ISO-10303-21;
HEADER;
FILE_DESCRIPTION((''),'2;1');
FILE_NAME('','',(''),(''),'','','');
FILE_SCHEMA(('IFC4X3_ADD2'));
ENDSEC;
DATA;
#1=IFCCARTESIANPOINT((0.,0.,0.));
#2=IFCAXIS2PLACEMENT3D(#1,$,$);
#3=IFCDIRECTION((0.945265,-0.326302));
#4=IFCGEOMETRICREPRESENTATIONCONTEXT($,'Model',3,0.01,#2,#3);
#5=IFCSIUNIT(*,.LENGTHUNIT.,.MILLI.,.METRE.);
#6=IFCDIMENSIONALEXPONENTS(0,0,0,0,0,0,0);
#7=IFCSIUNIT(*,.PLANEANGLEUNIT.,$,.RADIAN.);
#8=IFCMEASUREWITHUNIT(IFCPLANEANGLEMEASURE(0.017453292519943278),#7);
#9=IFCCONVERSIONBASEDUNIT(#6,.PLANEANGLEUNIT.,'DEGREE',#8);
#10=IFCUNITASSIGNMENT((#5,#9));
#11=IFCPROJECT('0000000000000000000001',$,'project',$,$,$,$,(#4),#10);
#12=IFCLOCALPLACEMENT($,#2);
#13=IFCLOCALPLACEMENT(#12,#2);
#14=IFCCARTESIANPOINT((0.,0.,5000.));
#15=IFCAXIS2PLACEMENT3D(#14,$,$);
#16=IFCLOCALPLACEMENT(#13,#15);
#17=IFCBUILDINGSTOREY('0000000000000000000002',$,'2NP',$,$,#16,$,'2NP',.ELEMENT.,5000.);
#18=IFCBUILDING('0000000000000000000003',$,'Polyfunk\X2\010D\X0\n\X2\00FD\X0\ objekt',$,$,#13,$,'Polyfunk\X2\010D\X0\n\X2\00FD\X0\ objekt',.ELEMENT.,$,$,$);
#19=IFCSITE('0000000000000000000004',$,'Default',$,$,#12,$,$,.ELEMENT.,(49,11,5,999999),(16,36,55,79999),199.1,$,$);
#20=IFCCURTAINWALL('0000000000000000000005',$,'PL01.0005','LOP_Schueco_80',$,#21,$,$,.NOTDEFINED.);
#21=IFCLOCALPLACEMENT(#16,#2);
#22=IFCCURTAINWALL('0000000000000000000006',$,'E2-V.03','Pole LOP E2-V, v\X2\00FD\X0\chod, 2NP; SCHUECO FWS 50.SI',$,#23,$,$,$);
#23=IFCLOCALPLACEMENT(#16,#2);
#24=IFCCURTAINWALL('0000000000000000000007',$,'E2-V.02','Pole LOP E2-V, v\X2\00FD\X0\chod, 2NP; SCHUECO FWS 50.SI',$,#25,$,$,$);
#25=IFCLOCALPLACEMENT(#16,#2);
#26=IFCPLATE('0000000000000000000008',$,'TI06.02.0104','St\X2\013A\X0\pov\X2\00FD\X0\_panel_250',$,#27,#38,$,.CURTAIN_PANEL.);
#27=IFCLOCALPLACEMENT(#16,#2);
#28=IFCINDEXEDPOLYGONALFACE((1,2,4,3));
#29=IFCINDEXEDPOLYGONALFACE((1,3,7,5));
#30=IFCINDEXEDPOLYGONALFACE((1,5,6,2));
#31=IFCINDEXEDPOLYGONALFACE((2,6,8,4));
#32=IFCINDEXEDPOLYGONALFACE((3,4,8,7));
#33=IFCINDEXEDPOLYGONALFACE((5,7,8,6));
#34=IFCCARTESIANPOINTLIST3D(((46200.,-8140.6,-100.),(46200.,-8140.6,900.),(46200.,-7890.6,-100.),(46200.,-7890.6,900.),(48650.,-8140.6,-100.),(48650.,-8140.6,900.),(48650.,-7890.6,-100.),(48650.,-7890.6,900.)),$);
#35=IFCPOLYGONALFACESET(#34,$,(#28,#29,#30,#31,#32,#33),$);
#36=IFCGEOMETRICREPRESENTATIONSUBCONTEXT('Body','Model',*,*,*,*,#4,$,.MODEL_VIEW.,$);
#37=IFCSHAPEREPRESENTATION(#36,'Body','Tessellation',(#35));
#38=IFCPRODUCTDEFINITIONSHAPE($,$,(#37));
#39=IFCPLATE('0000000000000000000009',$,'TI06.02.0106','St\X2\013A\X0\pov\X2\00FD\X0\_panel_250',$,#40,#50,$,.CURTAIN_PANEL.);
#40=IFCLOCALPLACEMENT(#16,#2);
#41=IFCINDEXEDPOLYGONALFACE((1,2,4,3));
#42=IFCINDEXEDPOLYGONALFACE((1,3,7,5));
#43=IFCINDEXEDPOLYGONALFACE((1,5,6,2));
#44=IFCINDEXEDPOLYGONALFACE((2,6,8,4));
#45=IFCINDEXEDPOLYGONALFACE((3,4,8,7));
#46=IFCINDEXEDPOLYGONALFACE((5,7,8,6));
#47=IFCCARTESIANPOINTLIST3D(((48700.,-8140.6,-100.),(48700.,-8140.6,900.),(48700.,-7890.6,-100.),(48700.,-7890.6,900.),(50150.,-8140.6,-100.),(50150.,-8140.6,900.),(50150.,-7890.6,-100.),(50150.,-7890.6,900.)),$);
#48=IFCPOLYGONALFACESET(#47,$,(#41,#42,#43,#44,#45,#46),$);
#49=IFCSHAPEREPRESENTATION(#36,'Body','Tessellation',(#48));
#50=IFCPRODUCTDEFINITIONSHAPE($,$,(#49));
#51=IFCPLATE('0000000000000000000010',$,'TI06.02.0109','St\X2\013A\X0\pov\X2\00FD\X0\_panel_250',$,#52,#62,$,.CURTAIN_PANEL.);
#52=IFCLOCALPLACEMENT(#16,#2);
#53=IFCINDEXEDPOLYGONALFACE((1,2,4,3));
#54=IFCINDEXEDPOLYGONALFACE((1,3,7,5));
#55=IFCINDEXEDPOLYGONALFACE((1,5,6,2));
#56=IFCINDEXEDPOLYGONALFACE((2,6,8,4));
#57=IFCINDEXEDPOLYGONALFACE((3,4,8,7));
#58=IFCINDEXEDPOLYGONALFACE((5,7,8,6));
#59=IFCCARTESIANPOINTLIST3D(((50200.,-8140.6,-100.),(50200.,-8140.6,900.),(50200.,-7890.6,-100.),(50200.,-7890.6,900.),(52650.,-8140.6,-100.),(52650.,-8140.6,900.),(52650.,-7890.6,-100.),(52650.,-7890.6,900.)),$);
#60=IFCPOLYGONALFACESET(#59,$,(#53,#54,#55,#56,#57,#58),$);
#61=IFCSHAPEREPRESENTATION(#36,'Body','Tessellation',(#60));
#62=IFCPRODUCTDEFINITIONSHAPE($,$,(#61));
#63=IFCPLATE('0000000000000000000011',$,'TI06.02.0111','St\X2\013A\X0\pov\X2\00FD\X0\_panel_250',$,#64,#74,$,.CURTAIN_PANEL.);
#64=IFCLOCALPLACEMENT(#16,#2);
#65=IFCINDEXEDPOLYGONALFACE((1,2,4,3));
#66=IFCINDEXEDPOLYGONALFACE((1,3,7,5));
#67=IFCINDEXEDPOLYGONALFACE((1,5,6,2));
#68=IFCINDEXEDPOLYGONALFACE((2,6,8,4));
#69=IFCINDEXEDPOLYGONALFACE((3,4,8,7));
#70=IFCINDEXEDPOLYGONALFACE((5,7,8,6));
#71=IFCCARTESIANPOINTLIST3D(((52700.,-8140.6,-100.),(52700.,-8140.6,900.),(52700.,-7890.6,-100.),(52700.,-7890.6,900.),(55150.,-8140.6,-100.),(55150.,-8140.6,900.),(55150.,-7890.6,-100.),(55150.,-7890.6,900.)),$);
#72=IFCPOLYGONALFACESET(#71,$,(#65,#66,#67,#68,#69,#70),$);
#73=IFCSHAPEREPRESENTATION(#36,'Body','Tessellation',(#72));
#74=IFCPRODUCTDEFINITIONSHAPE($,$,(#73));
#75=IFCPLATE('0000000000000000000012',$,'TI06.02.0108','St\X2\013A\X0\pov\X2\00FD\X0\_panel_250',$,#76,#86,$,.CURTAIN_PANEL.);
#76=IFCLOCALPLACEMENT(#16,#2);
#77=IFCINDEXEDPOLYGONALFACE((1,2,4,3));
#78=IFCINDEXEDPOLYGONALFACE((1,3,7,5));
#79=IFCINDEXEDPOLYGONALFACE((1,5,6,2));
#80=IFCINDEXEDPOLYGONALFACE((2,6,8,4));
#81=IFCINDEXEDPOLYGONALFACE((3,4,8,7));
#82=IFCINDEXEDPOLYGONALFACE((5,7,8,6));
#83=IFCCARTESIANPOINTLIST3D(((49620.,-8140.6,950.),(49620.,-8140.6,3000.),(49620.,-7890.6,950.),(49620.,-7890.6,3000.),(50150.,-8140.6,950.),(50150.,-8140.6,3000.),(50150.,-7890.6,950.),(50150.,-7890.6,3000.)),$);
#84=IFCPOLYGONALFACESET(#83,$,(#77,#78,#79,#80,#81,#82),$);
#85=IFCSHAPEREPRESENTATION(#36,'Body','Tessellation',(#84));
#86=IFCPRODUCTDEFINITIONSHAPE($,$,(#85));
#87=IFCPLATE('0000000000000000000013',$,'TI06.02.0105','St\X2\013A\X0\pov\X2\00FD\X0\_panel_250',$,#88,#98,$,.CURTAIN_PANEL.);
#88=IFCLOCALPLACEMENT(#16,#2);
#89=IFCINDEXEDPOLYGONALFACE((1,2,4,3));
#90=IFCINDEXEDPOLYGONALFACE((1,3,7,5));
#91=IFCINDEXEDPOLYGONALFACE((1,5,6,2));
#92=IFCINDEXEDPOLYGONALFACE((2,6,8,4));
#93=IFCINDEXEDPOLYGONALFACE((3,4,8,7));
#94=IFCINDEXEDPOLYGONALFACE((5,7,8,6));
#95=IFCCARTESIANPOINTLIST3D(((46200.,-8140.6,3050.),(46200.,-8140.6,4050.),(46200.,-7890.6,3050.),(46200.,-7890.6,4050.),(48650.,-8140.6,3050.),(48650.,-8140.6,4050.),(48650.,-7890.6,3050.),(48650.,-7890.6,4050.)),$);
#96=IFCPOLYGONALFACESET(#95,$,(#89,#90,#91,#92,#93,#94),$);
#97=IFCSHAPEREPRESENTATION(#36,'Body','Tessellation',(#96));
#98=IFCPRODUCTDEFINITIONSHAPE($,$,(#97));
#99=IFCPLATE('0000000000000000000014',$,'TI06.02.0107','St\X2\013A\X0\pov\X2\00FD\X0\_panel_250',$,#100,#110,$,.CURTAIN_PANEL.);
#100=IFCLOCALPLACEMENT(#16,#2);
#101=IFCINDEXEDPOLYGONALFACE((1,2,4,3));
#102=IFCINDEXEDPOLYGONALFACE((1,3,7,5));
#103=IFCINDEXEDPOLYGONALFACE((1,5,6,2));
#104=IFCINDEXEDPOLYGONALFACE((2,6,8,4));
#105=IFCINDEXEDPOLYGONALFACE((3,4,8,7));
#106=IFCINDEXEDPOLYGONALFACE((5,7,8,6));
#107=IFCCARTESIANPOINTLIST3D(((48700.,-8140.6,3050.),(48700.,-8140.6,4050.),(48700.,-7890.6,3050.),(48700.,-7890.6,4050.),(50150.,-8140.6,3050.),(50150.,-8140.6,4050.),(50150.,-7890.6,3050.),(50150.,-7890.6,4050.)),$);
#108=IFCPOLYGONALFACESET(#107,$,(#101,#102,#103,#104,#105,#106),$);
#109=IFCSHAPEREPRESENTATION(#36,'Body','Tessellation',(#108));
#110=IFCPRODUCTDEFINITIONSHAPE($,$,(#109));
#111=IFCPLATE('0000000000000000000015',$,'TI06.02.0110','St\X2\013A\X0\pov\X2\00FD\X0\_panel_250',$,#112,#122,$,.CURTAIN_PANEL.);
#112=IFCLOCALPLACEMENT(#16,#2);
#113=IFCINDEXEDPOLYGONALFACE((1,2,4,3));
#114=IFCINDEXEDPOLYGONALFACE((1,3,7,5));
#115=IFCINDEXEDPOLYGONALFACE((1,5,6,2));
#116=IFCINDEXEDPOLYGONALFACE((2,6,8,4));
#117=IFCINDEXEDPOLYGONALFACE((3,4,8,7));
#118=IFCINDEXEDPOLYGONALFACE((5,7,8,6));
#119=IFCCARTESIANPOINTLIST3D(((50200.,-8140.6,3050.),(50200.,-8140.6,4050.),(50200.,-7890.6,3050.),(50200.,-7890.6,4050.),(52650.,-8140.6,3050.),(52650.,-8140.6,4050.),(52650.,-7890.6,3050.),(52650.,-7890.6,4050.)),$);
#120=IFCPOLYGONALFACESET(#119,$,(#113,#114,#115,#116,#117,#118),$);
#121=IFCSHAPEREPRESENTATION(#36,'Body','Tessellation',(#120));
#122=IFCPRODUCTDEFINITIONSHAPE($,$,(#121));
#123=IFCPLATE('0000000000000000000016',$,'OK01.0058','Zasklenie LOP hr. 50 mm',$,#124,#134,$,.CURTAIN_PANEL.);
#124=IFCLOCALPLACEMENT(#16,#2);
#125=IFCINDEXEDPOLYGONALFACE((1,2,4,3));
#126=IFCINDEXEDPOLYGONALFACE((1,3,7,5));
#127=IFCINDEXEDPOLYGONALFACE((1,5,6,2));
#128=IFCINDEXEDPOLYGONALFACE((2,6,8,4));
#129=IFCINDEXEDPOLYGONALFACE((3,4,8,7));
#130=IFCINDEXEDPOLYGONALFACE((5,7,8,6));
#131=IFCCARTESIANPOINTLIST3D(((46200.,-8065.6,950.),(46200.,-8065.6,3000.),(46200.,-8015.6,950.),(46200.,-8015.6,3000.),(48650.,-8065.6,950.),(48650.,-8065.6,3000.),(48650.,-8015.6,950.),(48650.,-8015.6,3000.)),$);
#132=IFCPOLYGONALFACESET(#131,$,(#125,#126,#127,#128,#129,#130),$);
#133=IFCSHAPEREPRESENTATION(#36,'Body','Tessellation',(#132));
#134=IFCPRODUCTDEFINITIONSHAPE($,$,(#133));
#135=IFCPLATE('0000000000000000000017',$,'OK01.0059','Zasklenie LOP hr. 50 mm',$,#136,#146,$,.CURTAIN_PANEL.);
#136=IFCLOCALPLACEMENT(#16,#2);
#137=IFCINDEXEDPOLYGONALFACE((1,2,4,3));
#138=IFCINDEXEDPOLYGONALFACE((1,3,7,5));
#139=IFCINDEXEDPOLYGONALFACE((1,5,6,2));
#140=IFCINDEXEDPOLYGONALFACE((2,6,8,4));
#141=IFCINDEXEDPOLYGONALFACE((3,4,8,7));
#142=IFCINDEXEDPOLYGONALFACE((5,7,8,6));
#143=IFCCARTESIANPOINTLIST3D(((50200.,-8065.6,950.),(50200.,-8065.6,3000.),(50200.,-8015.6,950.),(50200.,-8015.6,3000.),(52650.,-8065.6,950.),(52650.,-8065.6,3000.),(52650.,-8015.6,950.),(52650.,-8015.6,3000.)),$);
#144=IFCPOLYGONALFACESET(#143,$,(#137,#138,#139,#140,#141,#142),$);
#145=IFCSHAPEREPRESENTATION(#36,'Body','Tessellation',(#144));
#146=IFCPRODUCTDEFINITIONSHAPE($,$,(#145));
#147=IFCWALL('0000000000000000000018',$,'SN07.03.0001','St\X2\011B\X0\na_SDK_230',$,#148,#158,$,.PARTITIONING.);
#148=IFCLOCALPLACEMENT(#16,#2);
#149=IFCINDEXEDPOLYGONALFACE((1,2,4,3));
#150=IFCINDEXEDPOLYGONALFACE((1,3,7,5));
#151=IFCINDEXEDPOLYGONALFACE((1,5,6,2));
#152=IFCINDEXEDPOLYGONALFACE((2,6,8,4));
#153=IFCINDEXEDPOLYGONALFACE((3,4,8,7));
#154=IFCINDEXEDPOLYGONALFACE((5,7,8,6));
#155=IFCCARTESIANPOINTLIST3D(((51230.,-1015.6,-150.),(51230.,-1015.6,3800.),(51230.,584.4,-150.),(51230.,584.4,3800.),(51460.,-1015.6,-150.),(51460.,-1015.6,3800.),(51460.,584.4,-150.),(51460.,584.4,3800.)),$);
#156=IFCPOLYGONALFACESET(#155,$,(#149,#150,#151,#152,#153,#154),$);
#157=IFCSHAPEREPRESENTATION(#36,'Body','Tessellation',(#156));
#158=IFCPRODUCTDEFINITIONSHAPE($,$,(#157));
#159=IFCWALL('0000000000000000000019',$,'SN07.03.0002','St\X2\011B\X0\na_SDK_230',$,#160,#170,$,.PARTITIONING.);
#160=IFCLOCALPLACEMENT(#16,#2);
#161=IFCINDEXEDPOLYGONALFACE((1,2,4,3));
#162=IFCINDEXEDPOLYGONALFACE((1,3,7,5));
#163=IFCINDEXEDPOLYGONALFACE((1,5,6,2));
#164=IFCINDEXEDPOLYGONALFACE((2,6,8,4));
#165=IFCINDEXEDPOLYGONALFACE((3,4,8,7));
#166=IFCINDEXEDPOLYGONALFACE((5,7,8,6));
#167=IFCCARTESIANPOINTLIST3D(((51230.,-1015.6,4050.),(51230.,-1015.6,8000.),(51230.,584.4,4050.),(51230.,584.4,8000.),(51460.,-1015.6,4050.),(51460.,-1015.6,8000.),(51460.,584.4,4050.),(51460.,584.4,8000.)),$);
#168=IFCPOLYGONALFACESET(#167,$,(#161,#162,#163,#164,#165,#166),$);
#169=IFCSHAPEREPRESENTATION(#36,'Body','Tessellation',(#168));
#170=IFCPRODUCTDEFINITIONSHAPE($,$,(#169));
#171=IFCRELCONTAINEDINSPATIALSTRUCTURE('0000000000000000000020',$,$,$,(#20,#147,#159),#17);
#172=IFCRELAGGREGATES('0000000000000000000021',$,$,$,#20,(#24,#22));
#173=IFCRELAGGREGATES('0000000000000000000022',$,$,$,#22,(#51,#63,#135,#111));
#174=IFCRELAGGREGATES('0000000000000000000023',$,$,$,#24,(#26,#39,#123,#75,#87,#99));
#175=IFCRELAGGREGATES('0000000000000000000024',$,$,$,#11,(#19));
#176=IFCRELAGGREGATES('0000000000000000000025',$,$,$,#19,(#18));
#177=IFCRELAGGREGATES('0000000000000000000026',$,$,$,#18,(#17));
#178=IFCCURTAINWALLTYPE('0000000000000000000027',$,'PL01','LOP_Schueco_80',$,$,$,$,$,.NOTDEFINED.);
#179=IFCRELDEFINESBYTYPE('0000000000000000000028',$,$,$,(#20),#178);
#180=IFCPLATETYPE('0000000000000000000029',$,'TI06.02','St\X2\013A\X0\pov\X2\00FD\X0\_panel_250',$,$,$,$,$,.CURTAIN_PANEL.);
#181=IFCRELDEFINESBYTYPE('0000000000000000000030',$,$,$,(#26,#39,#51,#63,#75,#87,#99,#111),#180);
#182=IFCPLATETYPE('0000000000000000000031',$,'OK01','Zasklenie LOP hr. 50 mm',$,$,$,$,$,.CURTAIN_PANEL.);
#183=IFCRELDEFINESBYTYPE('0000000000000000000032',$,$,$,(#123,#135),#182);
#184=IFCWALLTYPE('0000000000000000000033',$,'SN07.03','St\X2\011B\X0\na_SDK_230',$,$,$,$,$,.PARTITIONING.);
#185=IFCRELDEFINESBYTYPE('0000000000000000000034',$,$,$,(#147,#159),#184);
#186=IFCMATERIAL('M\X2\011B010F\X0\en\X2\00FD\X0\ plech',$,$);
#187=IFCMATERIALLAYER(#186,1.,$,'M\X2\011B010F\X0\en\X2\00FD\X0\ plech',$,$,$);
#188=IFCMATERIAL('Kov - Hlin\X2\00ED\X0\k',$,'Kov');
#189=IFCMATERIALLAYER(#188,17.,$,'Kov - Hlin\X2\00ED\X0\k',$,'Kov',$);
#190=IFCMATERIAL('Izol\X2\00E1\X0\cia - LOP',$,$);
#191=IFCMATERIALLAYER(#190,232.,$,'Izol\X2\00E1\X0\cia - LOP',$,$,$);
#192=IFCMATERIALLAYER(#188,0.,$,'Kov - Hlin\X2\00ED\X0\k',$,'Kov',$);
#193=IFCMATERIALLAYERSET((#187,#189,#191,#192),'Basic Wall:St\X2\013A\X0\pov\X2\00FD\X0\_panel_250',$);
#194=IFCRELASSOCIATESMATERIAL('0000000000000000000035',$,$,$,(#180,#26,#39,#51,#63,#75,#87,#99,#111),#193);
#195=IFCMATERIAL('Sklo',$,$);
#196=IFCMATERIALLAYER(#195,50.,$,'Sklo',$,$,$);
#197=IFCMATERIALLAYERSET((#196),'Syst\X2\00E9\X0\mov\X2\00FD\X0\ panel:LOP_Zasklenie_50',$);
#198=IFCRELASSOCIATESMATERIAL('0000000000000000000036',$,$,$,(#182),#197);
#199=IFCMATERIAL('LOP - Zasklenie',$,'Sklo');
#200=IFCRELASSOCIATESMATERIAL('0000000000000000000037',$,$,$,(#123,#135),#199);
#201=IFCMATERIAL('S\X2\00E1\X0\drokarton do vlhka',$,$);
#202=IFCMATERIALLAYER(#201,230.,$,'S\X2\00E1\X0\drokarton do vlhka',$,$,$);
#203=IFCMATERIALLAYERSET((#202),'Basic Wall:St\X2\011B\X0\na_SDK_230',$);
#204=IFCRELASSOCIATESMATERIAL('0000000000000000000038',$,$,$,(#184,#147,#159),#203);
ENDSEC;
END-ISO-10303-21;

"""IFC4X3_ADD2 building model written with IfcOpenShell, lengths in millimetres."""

from ifc_helpers import new_model, entity, si_unit, converted_unit, direction, frame, frame_2d, origin, origin_2d_with_axis, place, context, subcontext, project, spatial, polyline, rectangle, extrude, clip, bounded_halfspace, source, transform, mapped, material, layer, layer_set, layer_usage, type_object, type_shapes, element, aggregate, save


model = new_model("IFC4X3_ADD2")

# Units and contexts
model_context = context("Model", 3, precision=0.01, world=origin(), true_north=direction((0.945265, -0.326302)))
body_context = subcontext(model_context, "Body", "Model", "MODEL_VIEW")
ifc_project = project(units=[si_unit("LENGTHUNIT", "METRE", prefix="MILLI"), converted_unit("PLANEANGLEUNIT", "DEGREE", entity("IfcPlaneAngleMeasure", 0.017453292519943278), si_unit("PLANEANGLEUNIT", "RADIAN"), dimensions=[0, 0, 0, 0, 0, 0, 0])], contexts=[model_context])

# Site, building, storey
site_placement = place(None, origin())
site = spatial("IfcSite", under=ifc_project, at=site_placement, Name="Default", CompositionType="ELEMENT", RefLatitude=(49, 11, 5, 999999), RefLongitude=(16, 36, 55, 79999), RefElevation=199.1)
building_placement = place(site_placement, origin())
building = spatial("IfcBuilding", under=site, at=building_placement, Name="Polyfunkčný objekt", LongName="Polyfunkčný objekt", CompositionType="ELEMENT")
storey_placement = place(building_placement, frame((0.0, 0.0, 5000.0)))
storey = spatial("IfcBuildingStorey", under=building, at=storey_placement, Name="2NP", LongName="2NP", CompositionType="ELEMENT", Elevation=5000.0)

# Curtain walls, plates
curtain_wall_type = type_object("IfcCurtainWallType", Name="PL01", Description="LOP_Schueco_80", PredefinedType="NOTDEFINED")
curtain_wall_1_placement = place(storey_placement, frame((0.0, 0.0, -5000.0)))
curtain_wall_1 = element("IfcCurtainWall", 1, at=curtain_wall_1_placement, inside=storey, type_object=curtain_wall_type, Name="PL01.0005", Description="LOP_Schueco_80", PredefinedType="NOTDEFINED")
curtain_wall_2 = element("IfcCurtainWall", 2, Name="E2-V.03", Description="Pole LOP E2-V, východ, 2NP; SCHUECO FWS 50.SI")
curtain_wall_3 = element("IfcCurtainWall", 3, Name="E2-V.02", Description="Pole LOP E2-V, východ, 2NP; SCHUECO FWS 50.SI")
aggregate(curtain_wall_1, [curtain_wall_3, curtain_wall_2])
ifc_material_1 = material(Name="Měďený plech")
ifc_layer_1 = layer(ifc_material_1, 1.0, Name="Měďený plech")
ifc_material_2 = material(Name="Kov - Hliník", Category="Kov")
ifc_layer_2 = layer(ifc_material_2, 17.0, Name="Kov - Hliník", Category="Kov")
ifc_material_3 = material(Name="Izolácia - LOP")
ifc_layer_3 = layer(ifc_material_3, 232.0, Name="Izolácia - LOP")
ifc_layer_4 = layer(ifc_material_2, 0.0, Name="Kov - Hliník", Category="Kov")
ifc_layer_set_1 = layer_set([ifc_layer_1, ifc_layer_2, ifc_layer_3, ifc_layer_4], Name="Basic Wall:Stĺpový_panel_250")
ifc_layer_usage_1 = layer_usage(ifc_layer_set_1, "AXIS2", "POSITIVE", -125.0)
plate_type_1 = type_object("IfcPlateType", Name="TI06.02", Description="Stĺpový_panel_250", PredefinedType="CURTAIN_PANEL", material=ifc_layer_set_1)
plate_1_placement = place(storey_placement, frame((46200.0, -8015.6, -100.0)))
plate_1 = element("IfcPlate", 4, at=plate_1_placement, type_object=plate_type_1, material=ifc_layer_usage_1, Name="TI06.02.0104", Description="Stĺpový_panel_250", PredefinedType="CURTAIN_PANEL", context=body_context, shape_type="SweptSolid", body=[
    extrude(rectangle(XDim=250.0, YDim=2450.0, at=frame_2d((0.0, 0.0), x_axis=(1.0, 0.0))), frame((1225.0, 0.0, 0.0), z_axis=(0.0, 0.0, 1.0), x_axis=(0.0, 1.0, 0.0)), (0.0, 0.0, 1.0), 1000.0),
])
ifc_layer_usage_2 = layer_usage(ifc_layer_set_1, "AXIS2", "POSITIVE", -125.0)
plate_2_placement = place(storey_placement, frame((48700.0, -8015.6, -100.0)))
plate_2 = element("IfcPlate", 5, at=plate_2_placement, type_object=plate_type_1, material=ifc_layer_usage_2, Name="TI06.02.0106", Description="Stĺpový_panel_250", PredefinedType="CURTAIN_PANEL", context=body_context, shape_type="SweptSolid", body=[
    extrude(rectangle(XDim=250.0, YDim=1450.0, at=frame_2d((0.0, 0.0), x_axis=(1.0, 0.0))), frame((725.0, 0.0, 0.0), z_axis=(0.0, 0.0, 1.0), x_axis=(0.0, 1.0, 0.0)), (0.0, 0.0, 1.0), 1000.0),
])
ifc_layer_usage_3 = layer_usage(ifc_layer_set_1, "AXIS2", "POSITIVE", -125.0)
plate_3_placement = place(storey_placement, frame((50200.0, -8015.6, -100.0)))
plate_3 = element("IfcPlate", 6, at=plate_3_placement, type_object=plate_type_1, material=ifc_layer_usage_3, Name="TI06.02.0109", Description="Stĺpový_panel_250", PredefinedType="CURTAIN_PANEL", context=body_context, shape_type="SweptSolid", body=[
    extrude(rectangle(XDim=250.0, YDim=2450.0, at=origin_2d_with_axis()), frame((1225.0, 0.0, 0.0), z_axis=(0.0, 0.0, 1.0), x_axis=(0.0, 1.0, 0.0)), (0.0, 0.0, 1.0), 1000.0),
])
ifc_layer_usage_4 = layer_usage(ifc_layer_set_1, "AXIS2", "POSITIVE", -125.0)
plate_4_placement = place(storey_placement, frame((52700.0, -8015.6, -100.0)))
plate_4 = element("IfcPlate", 7, at=plate_4_placement, type_object=plate_type_1, material=ifc_layer_usage_4, Name="TI06.02.0111", Description="Stĺpový_panel_250", PredefinedType="CURTAIN_PANEL", context=body_context, shape_type="SweptSolid", body=[
    extrude(rectangle(XDim=250.0, YDim=2450.0, at=frame_2d((0.0, 0.0), x_axis=(1.0, 0.0))), frame((1225.0, 0.0, 0.0), z_axis=(0.0, 0.0, 1.0), x_axis=(0.0, 1.0, 0.0)), (0.0, 0.0, 1.0), 1000.0),
])
ifc_layer_usage_5 = layer_usage(ifc_layer_set_1, "AXIS2", "POSITIVE", -125.0)
plate_5_placement = place(storey_placement, frame((49620.0, -8015.6, 950.0)))
plate_5 = element("IfcPlate", 8, at=plate_5_placement, type_object=plate_type_1, material=ifc_layer_usage_5, Name="TI06.02.0108", Description="Stĺpový_panel_250", PredefinedType="CURTAIN_PANEL", context=body_context, shape_type="SweptSolid", body=[
    extrude(rectangle(XDim=250.0, YDim=530.0, at=frame_2d((0.0, 0.0), x_axis=(1.0, 0.0))), frame((265.0, 0.0, 0.0), z_axis=(0.0, 0.0, 1.0), x_axis=(0.0, 1.0, 0.0)), (0.0, 0.0, 1.0), 2050.0),
])
ifc_layer_usage_6 = layer_usage(ifc_layer_set_1, "AXIS2", "POSITIVE", -125.0)
plate_6_placement = place(storey_placement, frame((46200.0, -8015.6, 3050.0)))
plate_6 = element("IfcPlate", 9, at=plate_6_placement, type_object=plate_type_1, material=ifc_layer_usage_6, Name="TI06.02.0105", Description="Stĺpový_panel_250", PredefinedType="CURTAIN_PANEL", context=body_context, shape_type="SweptSolid", body=[
    extrude(rectangle(XDim=250.0, YDim=2450.0, at=frame_2d((0.0, 0.0), x_axis=(1.0, 0.0))), frame((1225.0, 0.0, 0.0), z_axis=(0.0, 0.0, 1.0), x_axis=(0.0, 1.0, 0.0)), (0.0, 0.0, 1.0), 1000.0),
])
ifc_layer_usage_7 = layer_usage(ifc_layer_set_1, "AXIS2", "POSITIVE", -125.0)
plate_7_placement = place(storey_placement, frame((48700.0, -8015.6, 3050.0)))
plate_7 = element("IfcPlate", 10, at=plate_7_placement, type_object=plate_type_1, material=ifc_layer_usage_7, Name="TI06.02.0107", Description="Stĺpový_panel_250", PredefinedType="CURTAIN_PANEL", context=body_context, shape_type="SweptSolid", body=[
    extrude(rectangle(XDim=250.0, YDim=1450.0, at=frame_2d((0.0, 0.0), x_axis=(1.0, 0.0))), frame((725.0, 0.0, 0.0), z_axis=(0.0, 0.0, 1.0), x_axis=(0.0, 1.0, 0.0)), (0.0, 0.0, 1.0), 1000.0),
])
ifc_layer_usage_8 = layer_usage(ifc_layer_set_1, "AXIS2", "POSITIVE", -125.0)
plate_8_placement = place(storey_placement, frame((50200.0, -8015.6, 3050.0)))
plate_8 = element("IfcPlate", 11, at=plate_8_placement, type_object=plate_type_1, material=ifc_layer_usage_8, Name="TI06.02.0110", Description="Stĺpový_panel_250", PredefinedType="CURTAIN_PANEL", context=body_context, shape_type="SweptSolid", body=[
    extrude(rectangle(XDim=250.0, YDim=2450.0, at=origin_2d_with_axis()), frame((1225.0, 0.0, 0.0), z_axis=(0.0, 0.0, 1.0), x_axis=(0.0, 1.0, 0.0)), (0.0, 0.0, 1.0), 1000.0),
])
ifc_material_4 = material(Name="LOP - Zasklenie", Category="Sklo")
ifc_material_5 = material(Name="Sklo")
ifc_layer_5 = layer(ifc_material_5, 50.0, Name="Sklo")
ifc_layer_set_2 = layer_set([ifc_layer_5], Name="Systémový panel:LOP_Zasklenie_50")
plate_type_2 = type_object("IfcPlateType", Name="OK01", Description="Zasklenie LOP hr. 50 mm", PredefinedType="CURTAIN_PANEL", material=ifc_layer_set_2)
shared_shape_1 = source(origin(), body_context, "Body", "SweptSolid", [
    extrude(rectangle(XDim=50.0, YDim=2450.0, at=origin_2d_with_axis()), frame((0.0, -25.0, 0.0), z_axis=(0.0, 0.0, 1.0), x_axis=(0.0, 1.0, 0.0)), (0.0, 0.0, 1.0), 2050.0),
])
type_shapes(plate_type_2, [shared_shape_1])
plate_9_placement = place(curtain_wall_1_placement, frame((47425.0, -8015.6, 5950.0)))
plate_9 = element("IfcPlate", 12, at=plate_9_placement, type_object=plate_type_2, material=ifc_material_4, Name="OK01.0058", Description="Zasklenie LOP hr. 50 mm", PredefinedType="CURTAIN_PANEL", context=body_context, shape_type="MappedRepresentation", body=[
    mapped(shared_shape_1, transform((0.0, 0.0, 0.0), scale=1.0)),
])
plate_10_placement = place(curtain_wall_1_placement, frame((51425.0, -8015.6, 5950.0)))
plate_10 = element("IfcPlate", 13, at=plate_10_placement, type_object=plate_type_2, material=ifc_material_4, Name="OK01.0059", Description="Zasklenie LOP hr. 50 mm", PredefinedType="CURTAIN_PANEL", context=body_context, shape_type="MappedRepresentation", body=[
    mapped(shared_shape_1, transform((0.0, 0.0, 0.0), scale=1.0)),
])
aggregate(curtain_wall_2, [plate_3, plate_4, plate_10, plate_8])

# Walls
ifc_material_6 = material(Name="Sádrokarton do vlhka")
ifc_layer_6 = layer(ifc_material_6, 230.0, Name="Sádrokarton do vlhka")
ifc_layer_set_3 = layer_set([ifc_layer_6], Name="Basic Wall:Stěna_SDK_230")
wall_type_1 = type_object("IfcWallType", Name="SN07.03", Description="Stěna_SDK_230", PredefinedType="PARTITIONING", material=ifc_layer_set_3)
wall_1_placement = place(storey_placement, frame((51345.0, 584.4, -150.0), z_axis=(0.0, 0.0, 1.0), x_axis=(0.0, -1.0, 0.0)))
element("IfcWall", 14, at=wall_1_placement, inside=storey, type_object=wall_type_1, material=ifc_layer_set_3, Name="SN07.03.0001", Description="Stěna_SDK_230", PredefinedType="PARTITIONING", context=body_context, shape_type="Clipping", body=[
    clip(clip(extrude(rectangle(XDim=1600.0, YDim=230.0, at=frame_2d((800.0, 0.0), x_axis=(-1.0, 0.0))), origin(), (0.0, 0.0, 1.0), 3950.0), bounded_halfspace(frame((1600.0, -115.0, 0.0), z_axis=(0.0, 0.0, 1.0), x_axis=(0.0, -1.0, 0.0)), True, frame((1600.0, -115.0, 0.0)), polyline([(0.0, 0.0), (0.0, 230.0), (-1600.0, 230.0), (-1600.0, 0.0), (0.0, 0.0)]))), bounded_halfspace(frame((0.0, -115.0, 3950.0), z_axis=(0.0, 0.0, -1.0), x_axis=(0.0, 1.0, 0.0)), True, frame((0.0, -115.0, 3950.0)), polyline([(0.0, 0.0), (1600.0, 0.0), (1600.0, 230.0), (0.0, 230.0), (0.0, 0.0)]))),
])
wall_2_placement = place(storey_placement, frame((51345.0, 584.4, 4050.0), z_axis=(0.0, 0.0, 1.0), x_axis=(0.0, -1.0, 0.0)))
element("IfcWall", 15, at=wall_2_placement, inside=storey, type_object=wall_type_1, material=ifc_layer_set_3, Name="SN07.03.0002", Description="Stěna_SDK_230", PredefinedType="PARTITIONING", context=body_context, shape_type="Clipping", body=[
    clip(clip(extrude(rectangle(XDim=1600.0, YDim=230.0, at=frame_2d((800.0, 0.0), x_axis=(-1.0, 0.0))), origin(), (0.0, 0.0, 1.0), 3950.0), bounded_halfspace(frame((1600.0, -115.0, 0.0), z_axis=(0.0, 0.0, 1.0), x_axis=(0.0, -1.0, 0.0)), True, frame((1600.0, -115.0, 0.0)), polyline([(0.0, 0.0), (0.0, 230.0), (-1600.0, 230.0), (-1600.0, 0.0), (0.0, 0.0)]))), bounded_halfspace(frame((0.0, -115.0, 3950.0), z_axis=(0.0, 0.0, -1.0), x_axis=(0.0, 1.0, 0.0)), True, frame((0.0, -115.0, 3950.0)), polyline([(0.0, 0.0), (1600.0, 0.0), (1600.0, 230.0), (0.0, 230.0), (0.0, 0.0)]))),
])

aggregate(curtain_wall_3, [plate_1, plate_2, plate_9, plate_5, plate_6, plate_7])

save(model, "model.ifc")
